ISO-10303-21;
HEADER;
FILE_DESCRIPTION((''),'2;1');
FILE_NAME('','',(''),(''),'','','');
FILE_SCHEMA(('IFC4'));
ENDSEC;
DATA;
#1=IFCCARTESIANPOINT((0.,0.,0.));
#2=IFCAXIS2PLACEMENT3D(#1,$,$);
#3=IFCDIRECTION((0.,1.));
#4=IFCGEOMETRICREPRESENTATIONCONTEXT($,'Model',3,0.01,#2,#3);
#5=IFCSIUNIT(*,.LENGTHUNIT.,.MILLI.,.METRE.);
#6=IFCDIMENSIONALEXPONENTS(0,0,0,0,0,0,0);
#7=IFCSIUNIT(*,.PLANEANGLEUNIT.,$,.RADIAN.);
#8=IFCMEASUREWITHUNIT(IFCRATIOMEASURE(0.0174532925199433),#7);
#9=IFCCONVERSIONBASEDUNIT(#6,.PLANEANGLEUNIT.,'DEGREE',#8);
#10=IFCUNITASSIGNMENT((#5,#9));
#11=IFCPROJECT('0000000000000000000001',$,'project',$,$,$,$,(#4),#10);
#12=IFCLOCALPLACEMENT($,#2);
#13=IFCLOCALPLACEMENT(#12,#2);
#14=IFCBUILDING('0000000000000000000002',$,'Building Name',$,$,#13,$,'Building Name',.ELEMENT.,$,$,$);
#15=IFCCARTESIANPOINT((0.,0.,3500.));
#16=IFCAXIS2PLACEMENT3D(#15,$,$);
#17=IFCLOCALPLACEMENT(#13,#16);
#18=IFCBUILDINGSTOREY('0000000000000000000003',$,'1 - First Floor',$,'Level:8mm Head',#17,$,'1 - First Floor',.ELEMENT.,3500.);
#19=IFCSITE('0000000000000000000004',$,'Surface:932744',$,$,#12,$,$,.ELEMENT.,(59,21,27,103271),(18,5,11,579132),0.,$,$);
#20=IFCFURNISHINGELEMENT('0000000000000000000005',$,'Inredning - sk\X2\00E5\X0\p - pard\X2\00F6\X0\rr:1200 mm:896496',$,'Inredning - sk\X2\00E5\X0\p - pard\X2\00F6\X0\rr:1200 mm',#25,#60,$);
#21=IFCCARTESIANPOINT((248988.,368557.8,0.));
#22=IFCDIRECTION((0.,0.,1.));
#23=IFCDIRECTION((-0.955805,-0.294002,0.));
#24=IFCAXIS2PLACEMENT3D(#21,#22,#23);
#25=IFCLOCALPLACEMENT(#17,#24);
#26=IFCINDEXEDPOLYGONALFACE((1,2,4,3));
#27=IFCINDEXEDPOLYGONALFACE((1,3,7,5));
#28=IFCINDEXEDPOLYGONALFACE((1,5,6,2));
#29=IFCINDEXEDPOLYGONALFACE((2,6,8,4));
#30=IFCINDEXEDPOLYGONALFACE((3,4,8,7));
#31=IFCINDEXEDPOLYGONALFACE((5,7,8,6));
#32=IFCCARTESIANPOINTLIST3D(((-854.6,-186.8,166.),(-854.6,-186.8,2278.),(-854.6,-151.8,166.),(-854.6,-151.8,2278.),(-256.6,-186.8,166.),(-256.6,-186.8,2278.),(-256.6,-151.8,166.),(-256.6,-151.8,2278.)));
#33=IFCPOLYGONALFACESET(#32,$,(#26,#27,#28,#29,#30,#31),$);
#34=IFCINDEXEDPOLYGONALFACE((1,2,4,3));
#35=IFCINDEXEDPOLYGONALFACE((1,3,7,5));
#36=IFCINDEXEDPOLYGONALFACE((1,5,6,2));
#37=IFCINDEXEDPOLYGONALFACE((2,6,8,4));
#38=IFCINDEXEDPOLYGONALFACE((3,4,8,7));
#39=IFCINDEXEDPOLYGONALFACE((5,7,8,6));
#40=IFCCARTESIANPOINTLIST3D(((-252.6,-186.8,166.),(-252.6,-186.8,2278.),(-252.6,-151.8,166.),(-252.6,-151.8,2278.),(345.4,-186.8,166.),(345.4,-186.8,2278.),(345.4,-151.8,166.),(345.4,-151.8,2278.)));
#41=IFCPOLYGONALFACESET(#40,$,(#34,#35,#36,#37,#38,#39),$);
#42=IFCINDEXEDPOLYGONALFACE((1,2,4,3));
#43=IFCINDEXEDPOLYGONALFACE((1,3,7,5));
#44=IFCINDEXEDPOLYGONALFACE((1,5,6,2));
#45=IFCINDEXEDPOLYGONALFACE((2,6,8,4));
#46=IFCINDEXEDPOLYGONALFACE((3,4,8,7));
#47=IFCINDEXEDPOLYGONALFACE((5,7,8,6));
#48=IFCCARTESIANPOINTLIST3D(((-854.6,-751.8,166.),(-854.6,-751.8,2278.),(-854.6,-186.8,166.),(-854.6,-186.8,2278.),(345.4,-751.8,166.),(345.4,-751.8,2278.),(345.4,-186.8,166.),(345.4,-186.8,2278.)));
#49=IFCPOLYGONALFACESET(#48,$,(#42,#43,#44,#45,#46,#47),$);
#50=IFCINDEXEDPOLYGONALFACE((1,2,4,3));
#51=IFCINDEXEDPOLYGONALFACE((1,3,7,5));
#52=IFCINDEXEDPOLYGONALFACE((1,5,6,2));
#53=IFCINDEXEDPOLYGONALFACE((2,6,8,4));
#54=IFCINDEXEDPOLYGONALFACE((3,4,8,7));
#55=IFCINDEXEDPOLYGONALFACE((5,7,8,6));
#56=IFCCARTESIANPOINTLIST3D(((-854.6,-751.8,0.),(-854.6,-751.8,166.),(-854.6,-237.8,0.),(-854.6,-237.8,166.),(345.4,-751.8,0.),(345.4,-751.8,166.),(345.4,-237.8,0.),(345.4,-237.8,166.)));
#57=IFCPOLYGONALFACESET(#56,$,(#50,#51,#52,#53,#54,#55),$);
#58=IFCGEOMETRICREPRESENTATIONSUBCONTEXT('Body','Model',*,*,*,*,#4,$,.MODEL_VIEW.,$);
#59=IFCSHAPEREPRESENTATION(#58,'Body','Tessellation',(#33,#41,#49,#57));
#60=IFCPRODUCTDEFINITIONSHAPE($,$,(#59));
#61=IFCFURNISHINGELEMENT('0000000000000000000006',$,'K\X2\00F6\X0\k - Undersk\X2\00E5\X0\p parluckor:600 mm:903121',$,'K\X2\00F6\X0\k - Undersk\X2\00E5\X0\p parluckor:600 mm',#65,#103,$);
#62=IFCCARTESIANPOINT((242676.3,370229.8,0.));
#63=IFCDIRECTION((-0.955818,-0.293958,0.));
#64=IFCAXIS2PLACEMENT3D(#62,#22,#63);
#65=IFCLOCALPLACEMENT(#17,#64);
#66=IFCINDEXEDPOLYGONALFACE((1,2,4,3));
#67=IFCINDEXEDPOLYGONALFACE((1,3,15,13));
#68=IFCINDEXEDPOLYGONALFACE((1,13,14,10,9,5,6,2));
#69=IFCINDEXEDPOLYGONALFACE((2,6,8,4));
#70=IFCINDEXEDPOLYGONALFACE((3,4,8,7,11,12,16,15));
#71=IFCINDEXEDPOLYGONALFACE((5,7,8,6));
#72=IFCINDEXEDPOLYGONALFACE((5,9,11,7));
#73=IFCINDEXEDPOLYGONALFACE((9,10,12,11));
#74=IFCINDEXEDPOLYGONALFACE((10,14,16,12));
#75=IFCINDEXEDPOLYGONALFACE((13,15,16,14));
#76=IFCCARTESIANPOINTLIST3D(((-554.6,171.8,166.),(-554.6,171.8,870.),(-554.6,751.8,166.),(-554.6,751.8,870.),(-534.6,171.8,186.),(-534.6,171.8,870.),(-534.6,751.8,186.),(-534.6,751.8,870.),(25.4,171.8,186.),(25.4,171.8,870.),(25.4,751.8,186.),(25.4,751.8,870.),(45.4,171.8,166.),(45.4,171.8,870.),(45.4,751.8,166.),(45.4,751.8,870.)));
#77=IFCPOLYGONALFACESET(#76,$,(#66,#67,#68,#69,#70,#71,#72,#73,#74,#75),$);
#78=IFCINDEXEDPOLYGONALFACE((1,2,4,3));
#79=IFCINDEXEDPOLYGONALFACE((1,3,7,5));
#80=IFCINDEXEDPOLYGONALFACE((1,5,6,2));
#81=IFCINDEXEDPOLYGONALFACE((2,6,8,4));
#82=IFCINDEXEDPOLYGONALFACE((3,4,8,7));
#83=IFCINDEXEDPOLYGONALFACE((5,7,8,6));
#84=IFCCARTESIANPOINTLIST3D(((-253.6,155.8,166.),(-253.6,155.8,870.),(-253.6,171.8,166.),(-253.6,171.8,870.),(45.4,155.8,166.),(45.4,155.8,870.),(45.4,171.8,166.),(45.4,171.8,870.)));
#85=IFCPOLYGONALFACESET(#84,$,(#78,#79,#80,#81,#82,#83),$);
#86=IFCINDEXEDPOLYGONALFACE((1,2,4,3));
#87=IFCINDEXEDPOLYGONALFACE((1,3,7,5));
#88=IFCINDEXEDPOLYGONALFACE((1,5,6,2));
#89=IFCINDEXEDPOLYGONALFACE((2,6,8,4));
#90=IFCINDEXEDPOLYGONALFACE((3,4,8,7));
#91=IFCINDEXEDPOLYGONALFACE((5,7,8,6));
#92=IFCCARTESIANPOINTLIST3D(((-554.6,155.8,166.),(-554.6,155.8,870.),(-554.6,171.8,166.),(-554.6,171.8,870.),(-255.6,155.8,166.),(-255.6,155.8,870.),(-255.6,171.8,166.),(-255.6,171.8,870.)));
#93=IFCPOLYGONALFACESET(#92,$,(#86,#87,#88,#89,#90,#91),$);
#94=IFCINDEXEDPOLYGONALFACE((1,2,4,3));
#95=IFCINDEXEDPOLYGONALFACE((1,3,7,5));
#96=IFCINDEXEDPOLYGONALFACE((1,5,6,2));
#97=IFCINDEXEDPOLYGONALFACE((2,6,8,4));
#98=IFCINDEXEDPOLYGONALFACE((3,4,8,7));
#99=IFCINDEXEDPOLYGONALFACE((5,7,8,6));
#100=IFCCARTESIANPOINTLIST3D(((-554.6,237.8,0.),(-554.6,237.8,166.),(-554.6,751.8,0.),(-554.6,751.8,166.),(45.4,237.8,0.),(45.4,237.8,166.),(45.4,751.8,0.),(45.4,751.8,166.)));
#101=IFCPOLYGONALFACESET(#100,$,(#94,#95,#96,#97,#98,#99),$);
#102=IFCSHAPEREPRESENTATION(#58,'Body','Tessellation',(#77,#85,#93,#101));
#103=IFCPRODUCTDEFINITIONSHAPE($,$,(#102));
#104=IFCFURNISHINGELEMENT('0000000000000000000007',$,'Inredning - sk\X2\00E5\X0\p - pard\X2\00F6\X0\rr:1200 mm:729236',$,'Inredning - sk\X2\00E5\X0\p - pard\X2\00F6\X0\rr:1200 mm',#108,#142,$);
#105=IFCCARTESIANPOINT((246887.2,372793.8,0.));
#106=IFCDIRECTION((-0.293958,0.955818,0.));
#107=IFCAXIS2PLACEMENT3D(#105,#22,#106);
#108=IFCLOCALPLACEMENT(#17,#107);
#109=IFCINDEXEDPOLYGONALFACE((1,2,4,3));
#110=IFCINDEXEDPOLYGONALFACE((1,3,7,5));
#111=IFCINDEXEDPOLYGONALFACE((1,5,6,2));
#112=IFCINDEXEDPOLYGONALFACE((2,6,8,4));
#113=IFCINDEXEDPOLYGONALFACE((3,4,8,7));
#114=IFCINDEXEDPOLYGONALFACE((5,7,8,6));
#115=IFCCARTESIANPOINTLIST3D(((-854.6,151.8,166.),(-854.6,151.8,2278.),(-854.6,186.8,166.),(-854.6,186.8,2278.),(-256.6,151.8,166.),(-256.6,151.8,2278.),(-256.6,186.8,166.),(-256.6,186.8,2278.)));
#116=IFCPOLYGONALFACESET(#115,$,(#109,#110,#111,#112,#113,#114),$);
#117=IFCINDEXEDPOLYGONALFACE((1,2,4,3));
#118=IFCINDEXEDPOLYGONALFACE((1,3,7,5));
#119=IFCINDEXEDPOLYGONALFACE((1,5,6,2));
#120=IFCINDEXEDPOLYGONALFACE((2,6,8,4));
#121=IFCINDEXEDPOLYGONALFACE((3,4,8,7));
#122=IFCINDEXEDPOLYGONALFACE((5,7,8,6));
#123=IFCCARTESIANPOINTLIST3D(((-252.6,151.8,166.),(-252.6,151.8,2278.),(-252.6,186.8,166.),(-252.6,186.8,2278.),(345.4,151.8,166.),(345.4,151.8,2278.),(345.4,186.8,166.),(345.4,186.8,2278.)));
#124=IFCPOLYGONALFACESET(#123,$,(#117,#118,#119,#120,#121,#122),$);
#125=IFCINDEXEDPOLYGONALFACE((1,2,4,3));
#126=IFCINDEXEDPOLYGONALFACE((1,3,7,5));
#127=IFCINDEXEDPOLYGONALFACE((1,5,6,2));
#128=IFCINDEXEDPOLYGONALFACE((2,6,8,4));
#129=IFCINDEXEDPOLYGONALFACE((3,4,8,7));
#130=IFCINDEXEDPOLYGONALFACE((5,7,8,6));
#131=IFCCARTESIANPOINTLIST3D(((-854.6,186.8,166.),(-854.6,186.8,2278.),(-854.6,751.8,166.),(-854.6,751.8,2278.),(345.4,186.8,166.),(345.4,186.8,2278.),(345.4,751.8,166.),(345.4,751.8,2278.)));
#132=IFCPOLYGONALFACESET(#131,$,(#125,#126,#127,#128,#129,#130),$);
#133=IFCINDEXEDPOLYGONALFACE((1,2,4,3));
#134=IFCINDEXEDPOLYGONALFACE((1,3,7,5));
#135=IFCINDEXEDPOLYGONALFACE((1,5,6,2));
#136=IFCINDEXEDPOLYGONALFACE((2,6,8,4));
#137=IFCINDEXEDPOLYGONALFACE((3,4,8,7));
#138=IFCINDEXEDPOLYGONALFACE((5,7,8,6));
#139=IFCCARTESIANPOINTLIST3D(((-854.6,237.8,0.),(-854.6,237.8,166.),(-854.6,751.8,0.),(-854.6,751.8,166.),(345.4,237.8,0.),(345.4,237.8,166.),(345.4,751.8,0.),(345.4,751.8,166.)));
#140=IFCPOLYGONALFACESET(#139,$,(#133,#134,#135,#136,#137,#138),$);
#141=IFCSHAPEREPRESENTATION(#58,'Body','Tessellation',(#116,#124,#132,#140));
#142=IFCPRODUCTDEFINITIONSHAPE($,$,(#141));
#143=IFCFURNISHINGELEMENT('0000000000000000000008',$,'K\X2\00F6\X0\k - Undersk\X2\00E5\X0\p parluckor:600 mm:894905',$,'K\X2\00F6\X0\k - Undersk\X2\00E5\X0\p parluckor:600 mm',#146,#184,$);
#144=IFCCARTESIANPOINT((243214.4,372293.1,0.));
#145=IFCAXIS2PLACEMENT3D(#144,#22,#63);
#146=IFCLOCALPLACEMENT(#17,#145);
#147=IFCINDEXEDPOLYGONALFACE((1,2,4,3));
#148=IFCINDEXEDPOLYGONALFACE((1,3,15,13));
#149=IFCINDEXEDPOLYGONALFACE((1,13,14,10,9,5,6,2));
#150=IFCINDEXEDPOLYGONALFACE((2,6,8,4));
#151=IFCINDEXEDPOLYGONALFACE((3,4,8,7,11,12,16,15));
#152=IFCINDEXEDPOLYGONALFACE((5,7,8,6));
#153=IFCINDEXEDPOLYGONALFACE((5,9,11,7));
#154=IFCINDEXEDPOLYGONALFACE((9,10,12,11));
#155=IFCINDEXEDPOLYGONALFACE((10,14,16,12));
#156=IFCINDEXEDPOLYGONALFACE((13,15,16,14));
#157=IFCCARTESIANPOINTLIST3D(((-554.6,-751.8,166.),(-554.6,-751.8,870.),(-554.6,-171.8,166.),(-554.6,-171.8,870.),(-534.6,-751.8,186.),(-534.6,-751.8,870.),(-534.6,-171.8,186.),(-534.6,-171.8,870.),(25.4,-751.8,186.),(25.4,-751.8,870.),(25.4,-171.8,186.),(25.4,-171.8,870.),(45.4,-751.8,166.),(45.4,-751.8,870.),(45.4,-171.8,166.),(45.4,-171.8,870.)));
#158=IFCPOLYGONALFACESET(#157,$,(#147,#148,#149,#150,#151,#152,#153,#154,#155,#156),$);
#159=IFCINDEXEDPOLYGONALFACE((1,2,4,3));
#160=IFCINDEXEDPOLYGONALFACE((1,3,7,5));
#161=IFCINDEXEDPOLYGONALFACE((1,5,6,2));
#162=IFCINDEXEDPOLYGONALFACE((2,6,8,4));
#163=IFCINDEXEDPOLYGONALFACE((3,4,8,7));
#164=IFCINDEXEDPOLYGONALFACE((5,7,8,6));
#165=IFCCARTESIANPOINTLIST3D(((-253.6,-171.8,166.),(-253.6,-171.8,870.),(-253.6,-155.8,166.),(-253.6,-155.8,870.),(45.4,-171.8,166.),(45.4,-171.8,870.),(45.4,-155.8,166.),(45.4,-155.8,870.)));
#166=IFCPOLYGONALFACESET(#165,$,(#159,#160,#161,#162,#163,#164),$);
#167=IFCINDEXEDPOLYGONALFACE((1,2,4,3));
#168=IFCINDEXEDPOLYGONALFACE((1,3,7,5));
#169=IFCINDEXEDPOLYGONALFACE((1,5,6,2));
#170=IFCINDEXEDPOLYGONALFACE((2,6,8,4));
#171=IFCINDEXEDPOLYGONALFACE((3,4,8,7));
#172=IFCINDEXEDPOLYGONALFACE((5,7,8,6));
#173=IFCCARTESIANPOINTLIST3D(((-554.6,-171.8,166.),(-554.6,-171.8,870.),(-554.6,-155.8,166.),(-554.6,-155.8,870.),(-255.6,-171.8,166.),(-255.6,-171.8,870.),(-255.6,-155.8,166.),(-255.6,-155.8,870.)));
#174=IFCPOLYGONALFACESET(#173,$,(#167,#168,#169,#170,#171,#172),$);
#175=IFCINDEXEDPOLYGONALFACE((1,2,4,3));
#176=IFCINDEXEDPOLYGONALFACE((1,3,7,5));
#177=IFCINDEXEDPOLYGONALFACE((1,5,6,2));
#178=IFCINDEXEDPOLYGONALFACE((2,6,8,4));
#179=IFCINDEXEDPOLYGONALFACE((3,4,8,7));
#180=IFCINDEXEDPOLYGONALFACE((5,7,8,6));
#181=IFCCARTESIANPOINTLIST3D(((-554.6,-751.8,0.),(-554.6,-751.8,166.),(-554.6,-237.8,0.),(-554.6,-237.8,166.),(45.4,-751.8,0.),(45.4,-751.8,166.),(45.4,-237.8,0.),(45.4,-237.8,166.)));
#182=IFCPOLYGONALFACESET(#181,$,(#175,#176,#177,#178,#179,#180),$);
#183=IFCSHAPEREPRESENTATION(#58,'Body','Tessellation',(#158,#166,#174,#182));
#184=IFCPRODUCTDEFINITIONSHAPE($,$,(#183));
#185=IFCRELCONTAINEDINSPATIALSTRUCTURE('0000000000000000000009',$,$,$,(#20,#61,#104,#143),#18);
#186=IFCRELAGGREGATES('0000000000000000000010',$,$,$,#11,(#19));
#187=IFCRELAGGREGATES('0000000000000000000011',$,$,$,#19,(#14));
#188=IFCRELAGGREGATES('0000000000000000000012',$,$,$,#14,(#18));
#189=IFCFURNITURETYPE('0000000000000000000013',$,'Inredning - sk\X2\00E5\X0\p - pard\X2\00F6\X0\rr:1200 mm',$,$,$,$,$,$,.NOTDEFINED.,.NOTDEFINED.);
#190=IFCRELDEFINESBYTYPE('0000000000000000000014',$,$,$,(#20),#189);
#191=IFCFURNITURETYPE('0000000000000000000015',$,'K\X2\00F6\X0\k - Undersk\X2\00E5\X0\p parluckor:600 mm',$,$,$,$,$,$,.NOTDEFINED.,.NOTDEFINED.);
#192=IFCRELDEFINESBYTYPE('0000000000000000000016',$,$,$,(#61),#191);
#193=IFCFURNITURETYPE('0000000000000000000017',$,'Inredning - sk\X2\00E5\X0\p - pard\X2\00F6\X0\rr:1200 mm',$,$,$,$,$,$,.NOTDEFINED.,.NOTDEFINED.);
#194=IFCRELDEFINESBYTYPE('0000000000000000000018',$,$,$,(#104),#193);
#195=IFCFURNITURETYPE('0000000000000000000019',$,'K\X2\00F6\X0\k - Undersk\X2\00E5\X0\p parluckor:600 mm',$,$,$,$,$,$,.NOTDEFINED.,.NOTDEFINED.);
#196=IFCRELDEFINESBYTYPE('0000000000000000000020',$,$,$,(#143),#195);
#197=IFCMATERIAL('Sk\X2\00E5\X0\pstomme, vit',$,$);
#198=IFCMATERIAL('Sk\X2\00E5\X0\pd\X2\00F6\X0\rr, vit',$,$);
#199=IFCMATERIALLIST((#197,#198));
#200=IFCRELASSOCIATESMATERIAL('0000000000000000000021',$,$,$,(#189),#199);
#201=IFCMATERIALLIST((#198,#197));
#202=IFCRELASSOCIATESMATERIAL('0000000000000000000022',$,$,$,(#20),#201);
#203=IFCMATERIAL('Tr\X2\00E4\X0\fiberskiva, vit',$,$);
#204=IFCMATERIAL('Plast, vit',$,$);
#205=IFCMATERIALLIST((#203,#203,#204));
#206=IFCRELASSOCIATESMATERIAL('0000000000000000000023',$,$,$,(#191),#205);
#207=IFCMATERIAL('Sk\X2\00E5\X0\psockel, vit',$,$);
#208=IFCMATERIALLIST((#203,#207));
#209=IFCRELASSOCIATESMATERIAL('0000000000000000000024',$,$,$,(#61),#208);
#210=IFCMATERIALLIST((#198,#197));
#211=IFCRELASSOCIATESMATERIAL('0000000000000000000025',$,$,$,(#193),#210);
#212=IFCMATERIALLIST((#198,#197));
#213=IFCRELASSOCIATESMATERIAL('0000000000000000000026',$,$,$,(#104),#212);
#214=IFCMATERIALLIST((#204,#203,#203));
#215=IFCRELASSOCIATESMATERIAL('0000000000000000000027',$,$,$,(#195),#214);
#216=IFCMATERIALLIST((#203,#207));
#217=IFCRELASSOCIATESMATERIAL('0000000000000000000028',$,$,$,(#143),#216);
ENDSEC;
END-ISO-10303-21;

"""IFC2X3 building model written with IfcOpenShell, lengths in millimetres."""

from ifc_helpers import new_model, entity, si_unit, converted_unit, direction, frame, frame_2d, origin, origin_2d_with_axis, place, context, subcontext, project, spatial, polyline, rectangle, outline, extrude, source, transform, mapped, material, material_list, type_object, type_shapes, element, save


model = new_model("IFC2X3")

# Units and contexts
model_context = context("Model", 3, precision=0.01, world=origin(), true_north=direction((0.0, 1.0)))
body_context = subcontext(model_context, "Body", "Model", "MODEL_VIEW")
ifc_project = project(units=[si_unit("LENGTHUNIT", "METRE", prefix="MILLI"), converted_unit("PLANEANGLEUNIT", "DEGREE", entity("IfcRatioMeasure", 0.0174532925199433), si_unit("PLANEANGLEUNIT", "RADIAN"), dimensions=[0, 0, 0, 0, 0, 0, 0])], contexts=[model_context])

# Site, building, storey
site_placement = place(None, origin())
site = spatial("IfcSite", under=ifc_project, at=site_placement, Name="Surface:932744", CompositionType="ELEMENT", RefLatitude=(59, 21, 27, 103271), RefLongitude=(18, 5, 11, 579132), RefElevation=0.0)
building_placement = place(site_placement, origin())
building = spatial("IfcBuilding", under=site, at=building_placement, Name="Building Name", LongName="Building Name", CompositionType="ELEMENT")
storey_placement = place(building_placement, frame((0.0, 0.0, 3500.0)))
storey = spatial("IfcBuildingStorey", under=building, at=storey_placement, Name="1 - First Floor", ObjectType="Level:8mm Head", LongName="1 - First Floor", CompositionType="ELEMENT", Elevation=3500.0)

# Furnishing elements
ifc_material_1 = material(Name="Skåpdörr, vit")
ifc_material_2 = material(Name="Skåpstomme, vit")
ifc_material_list_1 = material_list([ifc_material_1, ifc_material_2])
ifc_material_list_2 = material_list([ifc_material_2, ifc_material_1])
furniture_type_1 = type_object("IfcFurnitureType", Name="Inredning - skåp - pardörr:1200 mm", material=ifc_material_list_2)
shared_shape_1 = source(origin(), body_context, "Body", "SweptSolid", [
    extrude(rectangle(XDim=598.0, YDim=35.0, at=origin_2d_with_axis()), frame((-555.6, -169.3, 166.0)), (0.0, 0.0, 1.0), 2112.0),
    extrude(rectangle(XDim=598.0, YDim=35.0, at=frame_2d((0.0, 0.0), x_axis=(1.0, 0.0))), frame((46.4, -169.3, 166.0)), (0.0, 0.0, 1.0), 2112.0),
    extrude(rectangle(XDim=565.0, YDim=1200.0, at=origin_2d_with_axis()), frame((-254.6, -469.3, 166.0), z_axis=(0.0, 0.0, 1.0), x_axis=(0.0, 1.0, 0.0)), (0.0, 0.0, 1.0), 2112.0),
    extrude(rectangle(XDim=514.0, YDim=1200.0, at=origin_2d_with_axis()), frame((-254.6, -494.8, 0.0), z_axis=(0.0, 0.0, 1.0), x_axis=(0.0, 1.0, 0.0)), (0.0, 0.0, 1.0), 166.0),
])
type_shapes(furniture_type_1, [shared_shape_1])
furnishing_1_placement = place(storey_placement, frame((248988.0, 368557.8, 0.0), z_axis=(0.0, 0.0, 1.0), x_axis=(-0.955805, -0.294002, 0.0)))
element("IfcFurnishingElement", 1, at=furnishing_1_placement, inside=storey, type_object=furniture_type_1, material=ifc_material_list_1, Name="Inredning - skåp - pardörr:1200 mm:896496", ObjectType="Inredning - skåp - pardörr:1200 mm", context=body_context, shape_type="MappedRepresentation", body=[
    mapped(shared_shape_1, transform((0.0, 0.0, 0.0), scale=1.0)),
])
ifc_material_3 = material(Name="Träfiberskiva, vit")
ifc_material_4 = material(Name="Skåpsockel, vit")
ifc_material_list_3 = material_list([ifc_material_3, ifc_material_4])
ifc_material_5 = material(Name="Plast, vit")
ifc_material_list_4 = material_list([ifc_material_3, ifc_material_3, ifc_material_5])
furniture_type_2 = type_object("IfcFurnitureType", Name="Kök - Underskåp parluckor:600 mm", material=ifc_material_list_4)
shared_shape_2 = source(origin(), body_context, "Body", "SweptSolid", [
    extrude(outline(polyline([(-300.0, -347.0), (-280.0, -347.0), (-280.0, 337.0), (280.0, 337.0), (280.0, -347.0), (300.0, -347.0), (300.0, 357.0), (-300.0, 357.0), (-300.0, -347.0)])), frame((-254.6, 171.8, 523.0), z_axis=(0.0, 1.0, 0.0), x_axis=(1.0, 0.0, 0.0)), (0.0, 0.0, 1.0), 580.0),
    extrude(rectangle(XDim=16.0, YDim=299.0, at=frame_2d((0.0, 0.0), x_axis=(1.0, 0.0))), frame((-104.1, 163.8, 166.0), z_axis=(0.0, 0.0, 1.0), x_axis=(0.0, 1.0, 0.0)), (0.0, 0.0, 1.0), 704.0),
    extrude(rectangle(XDim=16.0, YDim=299.0, at=frame_2d((0.0, 0.0), x_axis=(1.0, 0.0))), frame((-405.1, 163.8, 166.0), z_axis=(0.0, 0.0, 1.0), x_axis=(0.0, 1.0, 0.0)), (0.0, 0.0, 1.0), 704.0),
    extrude(rectangle(XDim=600.0, YDim=514.0, at=frame_2d((0.0, 0.0), x_axis=(1.0, 0.0))), frame((-254.6, 494.8, 0.0), z_axis=(0.0, 0.0, 1.0), x_axis=(-1.0, 0.0, 0.0)), (0.0, 0.0, 1.0), 166.0),
])
type_shapes(furniture_type_2, [shared_shape_2])
furnishing_2_placement = place(storey_placement, frame((242676.3, 370229.8, 0.0), z_axis=(0.0, 0.0, 1.0), x_axis=(-0.955818, -0.293958, 0.0)))
element("IfcFurnishingElement", 2, at=furnishing_2_placement, inside=storey, type_object=furniture_type_2, material=ifc_material_list_3, Name="Kök - Underskåp parluckor:600 mm:903121", ObjectType="Kök - Underskåp parluckor:600 mm", context=body_context, shape_type="MappedRepresentation", body=[
    mapped(shared_shape_2, transform((0.0, 0.0, 0.0), scale=1.0)),
])
ifc_material_list_5 = material_list([ifc_material_1, ifc_material_2])
ifc_material_list_6 = material_list([ifc_material_1, ifc_material_2])
furniture_type_3 = type_object("IfcFurnitureType", Name="Inredning - skåp - pardörr:1200 mm", material=ifc_material_list_6)
shared_shape_3 = source(origin(), body_context, "Body", "SweptSolid", [
    extrude(rectangle(XDim=35.0, YDim=598.0, at=frame_2d((0.0, 0.0), x_axis=(1.0, 0.0))), frame((-555.6, 169.3, 166.0), z_axis=(0.0, 0.0, 1.0), x_axis=(0.0, -1.0, 0.0)), (0.0, 0.0, 1.0), 2112.0),
    extrude(rectangle(XDim=35.0, YDim=598.0, at=frame_2d((0.0, 0.0), x_axis=(1.0, 0.0))), frame((46.4, 169.3, 166.0), z_axis=(0.0, 0.0, 1.0), x_axis=(0.0, -1.0, 0.0)), (0.0, 0.0, 1.0), 2112.0),
    extrude(rectangle(XDim=1200.0, YDim=565.0, at=origin_2d_with_axis()), frame((-254.6, 469.3, 166.0), z_axis=(0.0, 0.0, 1.0), x_axis=(-1.0, 0.0, 0.0)), (0.0, 0.0, 1.0), 2112.0),
    extrude(rectangle(XDim=1200.0, YDim=514.0, at=frame_2d((0.0, 0.0), x_axis=(1.0, 0.0))), frame((-254.6, 494.8, 0.0), z_axis=(0.0, 0.0, 1.0), x_axis=(-1.0, 0.0, 0.0)), (0.0, 0.0, 1.0), 166.0),
])
type_shapes(furniture_type_3, [shared_shape_3])
furnishing_3_placement = place(storey_placement, frame((246887.2, 372793.8, 0.0), z_axis=(0.0, 0.0, 1.0), x_axis=(-0.293958, 0.955818, 0.0)))
element("IfcFurnishingElement", 3, at=furnishing_3_placement, inside=storey, type_object=furniture_type_3, material=ifc_material_list_5, Name="Inredning - skåp - pardörr:1200 mm:729236", ObjectType="Inredning - skåp - pardörr:1200 mm", context=body_context, shape_type="MappedRepresentation", body=[
    mapped(shared_shape_3, transform((0.0, 0.0, 0.0), scale=1.0)),
])
ifc_material_list_7 = material_list([ifc_material_3, ifc_material_4])
ifc_material_list_8 = material_list([ifc_material_5, ifc_material_3, ifc_material_3])
furniture_type_4 = type_object("IfcFurnitureType", Name="Kök - Underskåp parluckor:600 mm", material=ifc_material_list_8)
shared_shape_4 = source(origin(), body_context, "Body", "SweptSolid", [
    extrude(outline(polyline([(-300.0, -347.0), (-280.0, -347.0), (-280.0, 337.0), (280.0, 337.0), (280.0, -347.0), (300.0, -347.0), (300.0, 357.0), (-300.0, 357.0), (-300.0, -347.0)])), frame((-254.6, -751.8, 523.0), z_axis=(0.0, 1.0, 0.0), x_axis=(1.0, 0.0, 0.0)), (0.0, 0.0, 1.0), 580.0),
    extrude(rectangle(XDim=299.0, YDim=16.0, at=frame_2d((0.0, 0.0), x_axis=(1.0, 0.0))), frame((-104.1, -163.8, 166.0), z_axis=(0.0, 0.0, 1.0), x_axis=(-1.0, 0.0, 0.0)), (0.0, 0.0, 1.0), 704.0),
    extrude(rectangle(XDim=299.0, YDim=16.0, at=frame_2d((0.0, 0.0), x_axis=(1.0, 0.0))), frame((-405.1, -163.8, 166.0), z_axis=(0.0, 0.0, 1.0), x_axis=(-1.0, 0.0, 0.0)), (0.0, 0.0, 1.0), 704.0),
    extrude(rectangle(XDim=514.0, YDim=600.0, at=origin_2d_with_axis()), frame((-254.6, -494.8, 0.0), z_axis=(0.0, 0.0, 1.0), x_axis=(0.0, 1.0, 0.0)), (0.0, 0.0, 1.0), 166.0),
])
type_shapes(furniture_type_4, [shared_shape_4])
furnishing_4_placement = place(storey_placement, frame((243214.4, 372293.1, 0.0), z_axis=(0.0, 0.0, 1.0), x_axis=(-0.955818, -0.293958, 0.0)))
element("IfcFurnishingElement", 4, at=furnishing_4_placement, inside=storey, type_object=furniture_type_4, material=ifc_material_list_7, Name="Kök - Underskåp parluckor:600 mm:894905", ObjectType="Kök - Underskåp parluckor:600 mm", context=body_context, shape_type="MappedRepresentation", body=[
    mapped(shared_shape_4, transform((0.0, 0.0, 0.0), scale=1.0)),
])

save(model, "model.ifc")
